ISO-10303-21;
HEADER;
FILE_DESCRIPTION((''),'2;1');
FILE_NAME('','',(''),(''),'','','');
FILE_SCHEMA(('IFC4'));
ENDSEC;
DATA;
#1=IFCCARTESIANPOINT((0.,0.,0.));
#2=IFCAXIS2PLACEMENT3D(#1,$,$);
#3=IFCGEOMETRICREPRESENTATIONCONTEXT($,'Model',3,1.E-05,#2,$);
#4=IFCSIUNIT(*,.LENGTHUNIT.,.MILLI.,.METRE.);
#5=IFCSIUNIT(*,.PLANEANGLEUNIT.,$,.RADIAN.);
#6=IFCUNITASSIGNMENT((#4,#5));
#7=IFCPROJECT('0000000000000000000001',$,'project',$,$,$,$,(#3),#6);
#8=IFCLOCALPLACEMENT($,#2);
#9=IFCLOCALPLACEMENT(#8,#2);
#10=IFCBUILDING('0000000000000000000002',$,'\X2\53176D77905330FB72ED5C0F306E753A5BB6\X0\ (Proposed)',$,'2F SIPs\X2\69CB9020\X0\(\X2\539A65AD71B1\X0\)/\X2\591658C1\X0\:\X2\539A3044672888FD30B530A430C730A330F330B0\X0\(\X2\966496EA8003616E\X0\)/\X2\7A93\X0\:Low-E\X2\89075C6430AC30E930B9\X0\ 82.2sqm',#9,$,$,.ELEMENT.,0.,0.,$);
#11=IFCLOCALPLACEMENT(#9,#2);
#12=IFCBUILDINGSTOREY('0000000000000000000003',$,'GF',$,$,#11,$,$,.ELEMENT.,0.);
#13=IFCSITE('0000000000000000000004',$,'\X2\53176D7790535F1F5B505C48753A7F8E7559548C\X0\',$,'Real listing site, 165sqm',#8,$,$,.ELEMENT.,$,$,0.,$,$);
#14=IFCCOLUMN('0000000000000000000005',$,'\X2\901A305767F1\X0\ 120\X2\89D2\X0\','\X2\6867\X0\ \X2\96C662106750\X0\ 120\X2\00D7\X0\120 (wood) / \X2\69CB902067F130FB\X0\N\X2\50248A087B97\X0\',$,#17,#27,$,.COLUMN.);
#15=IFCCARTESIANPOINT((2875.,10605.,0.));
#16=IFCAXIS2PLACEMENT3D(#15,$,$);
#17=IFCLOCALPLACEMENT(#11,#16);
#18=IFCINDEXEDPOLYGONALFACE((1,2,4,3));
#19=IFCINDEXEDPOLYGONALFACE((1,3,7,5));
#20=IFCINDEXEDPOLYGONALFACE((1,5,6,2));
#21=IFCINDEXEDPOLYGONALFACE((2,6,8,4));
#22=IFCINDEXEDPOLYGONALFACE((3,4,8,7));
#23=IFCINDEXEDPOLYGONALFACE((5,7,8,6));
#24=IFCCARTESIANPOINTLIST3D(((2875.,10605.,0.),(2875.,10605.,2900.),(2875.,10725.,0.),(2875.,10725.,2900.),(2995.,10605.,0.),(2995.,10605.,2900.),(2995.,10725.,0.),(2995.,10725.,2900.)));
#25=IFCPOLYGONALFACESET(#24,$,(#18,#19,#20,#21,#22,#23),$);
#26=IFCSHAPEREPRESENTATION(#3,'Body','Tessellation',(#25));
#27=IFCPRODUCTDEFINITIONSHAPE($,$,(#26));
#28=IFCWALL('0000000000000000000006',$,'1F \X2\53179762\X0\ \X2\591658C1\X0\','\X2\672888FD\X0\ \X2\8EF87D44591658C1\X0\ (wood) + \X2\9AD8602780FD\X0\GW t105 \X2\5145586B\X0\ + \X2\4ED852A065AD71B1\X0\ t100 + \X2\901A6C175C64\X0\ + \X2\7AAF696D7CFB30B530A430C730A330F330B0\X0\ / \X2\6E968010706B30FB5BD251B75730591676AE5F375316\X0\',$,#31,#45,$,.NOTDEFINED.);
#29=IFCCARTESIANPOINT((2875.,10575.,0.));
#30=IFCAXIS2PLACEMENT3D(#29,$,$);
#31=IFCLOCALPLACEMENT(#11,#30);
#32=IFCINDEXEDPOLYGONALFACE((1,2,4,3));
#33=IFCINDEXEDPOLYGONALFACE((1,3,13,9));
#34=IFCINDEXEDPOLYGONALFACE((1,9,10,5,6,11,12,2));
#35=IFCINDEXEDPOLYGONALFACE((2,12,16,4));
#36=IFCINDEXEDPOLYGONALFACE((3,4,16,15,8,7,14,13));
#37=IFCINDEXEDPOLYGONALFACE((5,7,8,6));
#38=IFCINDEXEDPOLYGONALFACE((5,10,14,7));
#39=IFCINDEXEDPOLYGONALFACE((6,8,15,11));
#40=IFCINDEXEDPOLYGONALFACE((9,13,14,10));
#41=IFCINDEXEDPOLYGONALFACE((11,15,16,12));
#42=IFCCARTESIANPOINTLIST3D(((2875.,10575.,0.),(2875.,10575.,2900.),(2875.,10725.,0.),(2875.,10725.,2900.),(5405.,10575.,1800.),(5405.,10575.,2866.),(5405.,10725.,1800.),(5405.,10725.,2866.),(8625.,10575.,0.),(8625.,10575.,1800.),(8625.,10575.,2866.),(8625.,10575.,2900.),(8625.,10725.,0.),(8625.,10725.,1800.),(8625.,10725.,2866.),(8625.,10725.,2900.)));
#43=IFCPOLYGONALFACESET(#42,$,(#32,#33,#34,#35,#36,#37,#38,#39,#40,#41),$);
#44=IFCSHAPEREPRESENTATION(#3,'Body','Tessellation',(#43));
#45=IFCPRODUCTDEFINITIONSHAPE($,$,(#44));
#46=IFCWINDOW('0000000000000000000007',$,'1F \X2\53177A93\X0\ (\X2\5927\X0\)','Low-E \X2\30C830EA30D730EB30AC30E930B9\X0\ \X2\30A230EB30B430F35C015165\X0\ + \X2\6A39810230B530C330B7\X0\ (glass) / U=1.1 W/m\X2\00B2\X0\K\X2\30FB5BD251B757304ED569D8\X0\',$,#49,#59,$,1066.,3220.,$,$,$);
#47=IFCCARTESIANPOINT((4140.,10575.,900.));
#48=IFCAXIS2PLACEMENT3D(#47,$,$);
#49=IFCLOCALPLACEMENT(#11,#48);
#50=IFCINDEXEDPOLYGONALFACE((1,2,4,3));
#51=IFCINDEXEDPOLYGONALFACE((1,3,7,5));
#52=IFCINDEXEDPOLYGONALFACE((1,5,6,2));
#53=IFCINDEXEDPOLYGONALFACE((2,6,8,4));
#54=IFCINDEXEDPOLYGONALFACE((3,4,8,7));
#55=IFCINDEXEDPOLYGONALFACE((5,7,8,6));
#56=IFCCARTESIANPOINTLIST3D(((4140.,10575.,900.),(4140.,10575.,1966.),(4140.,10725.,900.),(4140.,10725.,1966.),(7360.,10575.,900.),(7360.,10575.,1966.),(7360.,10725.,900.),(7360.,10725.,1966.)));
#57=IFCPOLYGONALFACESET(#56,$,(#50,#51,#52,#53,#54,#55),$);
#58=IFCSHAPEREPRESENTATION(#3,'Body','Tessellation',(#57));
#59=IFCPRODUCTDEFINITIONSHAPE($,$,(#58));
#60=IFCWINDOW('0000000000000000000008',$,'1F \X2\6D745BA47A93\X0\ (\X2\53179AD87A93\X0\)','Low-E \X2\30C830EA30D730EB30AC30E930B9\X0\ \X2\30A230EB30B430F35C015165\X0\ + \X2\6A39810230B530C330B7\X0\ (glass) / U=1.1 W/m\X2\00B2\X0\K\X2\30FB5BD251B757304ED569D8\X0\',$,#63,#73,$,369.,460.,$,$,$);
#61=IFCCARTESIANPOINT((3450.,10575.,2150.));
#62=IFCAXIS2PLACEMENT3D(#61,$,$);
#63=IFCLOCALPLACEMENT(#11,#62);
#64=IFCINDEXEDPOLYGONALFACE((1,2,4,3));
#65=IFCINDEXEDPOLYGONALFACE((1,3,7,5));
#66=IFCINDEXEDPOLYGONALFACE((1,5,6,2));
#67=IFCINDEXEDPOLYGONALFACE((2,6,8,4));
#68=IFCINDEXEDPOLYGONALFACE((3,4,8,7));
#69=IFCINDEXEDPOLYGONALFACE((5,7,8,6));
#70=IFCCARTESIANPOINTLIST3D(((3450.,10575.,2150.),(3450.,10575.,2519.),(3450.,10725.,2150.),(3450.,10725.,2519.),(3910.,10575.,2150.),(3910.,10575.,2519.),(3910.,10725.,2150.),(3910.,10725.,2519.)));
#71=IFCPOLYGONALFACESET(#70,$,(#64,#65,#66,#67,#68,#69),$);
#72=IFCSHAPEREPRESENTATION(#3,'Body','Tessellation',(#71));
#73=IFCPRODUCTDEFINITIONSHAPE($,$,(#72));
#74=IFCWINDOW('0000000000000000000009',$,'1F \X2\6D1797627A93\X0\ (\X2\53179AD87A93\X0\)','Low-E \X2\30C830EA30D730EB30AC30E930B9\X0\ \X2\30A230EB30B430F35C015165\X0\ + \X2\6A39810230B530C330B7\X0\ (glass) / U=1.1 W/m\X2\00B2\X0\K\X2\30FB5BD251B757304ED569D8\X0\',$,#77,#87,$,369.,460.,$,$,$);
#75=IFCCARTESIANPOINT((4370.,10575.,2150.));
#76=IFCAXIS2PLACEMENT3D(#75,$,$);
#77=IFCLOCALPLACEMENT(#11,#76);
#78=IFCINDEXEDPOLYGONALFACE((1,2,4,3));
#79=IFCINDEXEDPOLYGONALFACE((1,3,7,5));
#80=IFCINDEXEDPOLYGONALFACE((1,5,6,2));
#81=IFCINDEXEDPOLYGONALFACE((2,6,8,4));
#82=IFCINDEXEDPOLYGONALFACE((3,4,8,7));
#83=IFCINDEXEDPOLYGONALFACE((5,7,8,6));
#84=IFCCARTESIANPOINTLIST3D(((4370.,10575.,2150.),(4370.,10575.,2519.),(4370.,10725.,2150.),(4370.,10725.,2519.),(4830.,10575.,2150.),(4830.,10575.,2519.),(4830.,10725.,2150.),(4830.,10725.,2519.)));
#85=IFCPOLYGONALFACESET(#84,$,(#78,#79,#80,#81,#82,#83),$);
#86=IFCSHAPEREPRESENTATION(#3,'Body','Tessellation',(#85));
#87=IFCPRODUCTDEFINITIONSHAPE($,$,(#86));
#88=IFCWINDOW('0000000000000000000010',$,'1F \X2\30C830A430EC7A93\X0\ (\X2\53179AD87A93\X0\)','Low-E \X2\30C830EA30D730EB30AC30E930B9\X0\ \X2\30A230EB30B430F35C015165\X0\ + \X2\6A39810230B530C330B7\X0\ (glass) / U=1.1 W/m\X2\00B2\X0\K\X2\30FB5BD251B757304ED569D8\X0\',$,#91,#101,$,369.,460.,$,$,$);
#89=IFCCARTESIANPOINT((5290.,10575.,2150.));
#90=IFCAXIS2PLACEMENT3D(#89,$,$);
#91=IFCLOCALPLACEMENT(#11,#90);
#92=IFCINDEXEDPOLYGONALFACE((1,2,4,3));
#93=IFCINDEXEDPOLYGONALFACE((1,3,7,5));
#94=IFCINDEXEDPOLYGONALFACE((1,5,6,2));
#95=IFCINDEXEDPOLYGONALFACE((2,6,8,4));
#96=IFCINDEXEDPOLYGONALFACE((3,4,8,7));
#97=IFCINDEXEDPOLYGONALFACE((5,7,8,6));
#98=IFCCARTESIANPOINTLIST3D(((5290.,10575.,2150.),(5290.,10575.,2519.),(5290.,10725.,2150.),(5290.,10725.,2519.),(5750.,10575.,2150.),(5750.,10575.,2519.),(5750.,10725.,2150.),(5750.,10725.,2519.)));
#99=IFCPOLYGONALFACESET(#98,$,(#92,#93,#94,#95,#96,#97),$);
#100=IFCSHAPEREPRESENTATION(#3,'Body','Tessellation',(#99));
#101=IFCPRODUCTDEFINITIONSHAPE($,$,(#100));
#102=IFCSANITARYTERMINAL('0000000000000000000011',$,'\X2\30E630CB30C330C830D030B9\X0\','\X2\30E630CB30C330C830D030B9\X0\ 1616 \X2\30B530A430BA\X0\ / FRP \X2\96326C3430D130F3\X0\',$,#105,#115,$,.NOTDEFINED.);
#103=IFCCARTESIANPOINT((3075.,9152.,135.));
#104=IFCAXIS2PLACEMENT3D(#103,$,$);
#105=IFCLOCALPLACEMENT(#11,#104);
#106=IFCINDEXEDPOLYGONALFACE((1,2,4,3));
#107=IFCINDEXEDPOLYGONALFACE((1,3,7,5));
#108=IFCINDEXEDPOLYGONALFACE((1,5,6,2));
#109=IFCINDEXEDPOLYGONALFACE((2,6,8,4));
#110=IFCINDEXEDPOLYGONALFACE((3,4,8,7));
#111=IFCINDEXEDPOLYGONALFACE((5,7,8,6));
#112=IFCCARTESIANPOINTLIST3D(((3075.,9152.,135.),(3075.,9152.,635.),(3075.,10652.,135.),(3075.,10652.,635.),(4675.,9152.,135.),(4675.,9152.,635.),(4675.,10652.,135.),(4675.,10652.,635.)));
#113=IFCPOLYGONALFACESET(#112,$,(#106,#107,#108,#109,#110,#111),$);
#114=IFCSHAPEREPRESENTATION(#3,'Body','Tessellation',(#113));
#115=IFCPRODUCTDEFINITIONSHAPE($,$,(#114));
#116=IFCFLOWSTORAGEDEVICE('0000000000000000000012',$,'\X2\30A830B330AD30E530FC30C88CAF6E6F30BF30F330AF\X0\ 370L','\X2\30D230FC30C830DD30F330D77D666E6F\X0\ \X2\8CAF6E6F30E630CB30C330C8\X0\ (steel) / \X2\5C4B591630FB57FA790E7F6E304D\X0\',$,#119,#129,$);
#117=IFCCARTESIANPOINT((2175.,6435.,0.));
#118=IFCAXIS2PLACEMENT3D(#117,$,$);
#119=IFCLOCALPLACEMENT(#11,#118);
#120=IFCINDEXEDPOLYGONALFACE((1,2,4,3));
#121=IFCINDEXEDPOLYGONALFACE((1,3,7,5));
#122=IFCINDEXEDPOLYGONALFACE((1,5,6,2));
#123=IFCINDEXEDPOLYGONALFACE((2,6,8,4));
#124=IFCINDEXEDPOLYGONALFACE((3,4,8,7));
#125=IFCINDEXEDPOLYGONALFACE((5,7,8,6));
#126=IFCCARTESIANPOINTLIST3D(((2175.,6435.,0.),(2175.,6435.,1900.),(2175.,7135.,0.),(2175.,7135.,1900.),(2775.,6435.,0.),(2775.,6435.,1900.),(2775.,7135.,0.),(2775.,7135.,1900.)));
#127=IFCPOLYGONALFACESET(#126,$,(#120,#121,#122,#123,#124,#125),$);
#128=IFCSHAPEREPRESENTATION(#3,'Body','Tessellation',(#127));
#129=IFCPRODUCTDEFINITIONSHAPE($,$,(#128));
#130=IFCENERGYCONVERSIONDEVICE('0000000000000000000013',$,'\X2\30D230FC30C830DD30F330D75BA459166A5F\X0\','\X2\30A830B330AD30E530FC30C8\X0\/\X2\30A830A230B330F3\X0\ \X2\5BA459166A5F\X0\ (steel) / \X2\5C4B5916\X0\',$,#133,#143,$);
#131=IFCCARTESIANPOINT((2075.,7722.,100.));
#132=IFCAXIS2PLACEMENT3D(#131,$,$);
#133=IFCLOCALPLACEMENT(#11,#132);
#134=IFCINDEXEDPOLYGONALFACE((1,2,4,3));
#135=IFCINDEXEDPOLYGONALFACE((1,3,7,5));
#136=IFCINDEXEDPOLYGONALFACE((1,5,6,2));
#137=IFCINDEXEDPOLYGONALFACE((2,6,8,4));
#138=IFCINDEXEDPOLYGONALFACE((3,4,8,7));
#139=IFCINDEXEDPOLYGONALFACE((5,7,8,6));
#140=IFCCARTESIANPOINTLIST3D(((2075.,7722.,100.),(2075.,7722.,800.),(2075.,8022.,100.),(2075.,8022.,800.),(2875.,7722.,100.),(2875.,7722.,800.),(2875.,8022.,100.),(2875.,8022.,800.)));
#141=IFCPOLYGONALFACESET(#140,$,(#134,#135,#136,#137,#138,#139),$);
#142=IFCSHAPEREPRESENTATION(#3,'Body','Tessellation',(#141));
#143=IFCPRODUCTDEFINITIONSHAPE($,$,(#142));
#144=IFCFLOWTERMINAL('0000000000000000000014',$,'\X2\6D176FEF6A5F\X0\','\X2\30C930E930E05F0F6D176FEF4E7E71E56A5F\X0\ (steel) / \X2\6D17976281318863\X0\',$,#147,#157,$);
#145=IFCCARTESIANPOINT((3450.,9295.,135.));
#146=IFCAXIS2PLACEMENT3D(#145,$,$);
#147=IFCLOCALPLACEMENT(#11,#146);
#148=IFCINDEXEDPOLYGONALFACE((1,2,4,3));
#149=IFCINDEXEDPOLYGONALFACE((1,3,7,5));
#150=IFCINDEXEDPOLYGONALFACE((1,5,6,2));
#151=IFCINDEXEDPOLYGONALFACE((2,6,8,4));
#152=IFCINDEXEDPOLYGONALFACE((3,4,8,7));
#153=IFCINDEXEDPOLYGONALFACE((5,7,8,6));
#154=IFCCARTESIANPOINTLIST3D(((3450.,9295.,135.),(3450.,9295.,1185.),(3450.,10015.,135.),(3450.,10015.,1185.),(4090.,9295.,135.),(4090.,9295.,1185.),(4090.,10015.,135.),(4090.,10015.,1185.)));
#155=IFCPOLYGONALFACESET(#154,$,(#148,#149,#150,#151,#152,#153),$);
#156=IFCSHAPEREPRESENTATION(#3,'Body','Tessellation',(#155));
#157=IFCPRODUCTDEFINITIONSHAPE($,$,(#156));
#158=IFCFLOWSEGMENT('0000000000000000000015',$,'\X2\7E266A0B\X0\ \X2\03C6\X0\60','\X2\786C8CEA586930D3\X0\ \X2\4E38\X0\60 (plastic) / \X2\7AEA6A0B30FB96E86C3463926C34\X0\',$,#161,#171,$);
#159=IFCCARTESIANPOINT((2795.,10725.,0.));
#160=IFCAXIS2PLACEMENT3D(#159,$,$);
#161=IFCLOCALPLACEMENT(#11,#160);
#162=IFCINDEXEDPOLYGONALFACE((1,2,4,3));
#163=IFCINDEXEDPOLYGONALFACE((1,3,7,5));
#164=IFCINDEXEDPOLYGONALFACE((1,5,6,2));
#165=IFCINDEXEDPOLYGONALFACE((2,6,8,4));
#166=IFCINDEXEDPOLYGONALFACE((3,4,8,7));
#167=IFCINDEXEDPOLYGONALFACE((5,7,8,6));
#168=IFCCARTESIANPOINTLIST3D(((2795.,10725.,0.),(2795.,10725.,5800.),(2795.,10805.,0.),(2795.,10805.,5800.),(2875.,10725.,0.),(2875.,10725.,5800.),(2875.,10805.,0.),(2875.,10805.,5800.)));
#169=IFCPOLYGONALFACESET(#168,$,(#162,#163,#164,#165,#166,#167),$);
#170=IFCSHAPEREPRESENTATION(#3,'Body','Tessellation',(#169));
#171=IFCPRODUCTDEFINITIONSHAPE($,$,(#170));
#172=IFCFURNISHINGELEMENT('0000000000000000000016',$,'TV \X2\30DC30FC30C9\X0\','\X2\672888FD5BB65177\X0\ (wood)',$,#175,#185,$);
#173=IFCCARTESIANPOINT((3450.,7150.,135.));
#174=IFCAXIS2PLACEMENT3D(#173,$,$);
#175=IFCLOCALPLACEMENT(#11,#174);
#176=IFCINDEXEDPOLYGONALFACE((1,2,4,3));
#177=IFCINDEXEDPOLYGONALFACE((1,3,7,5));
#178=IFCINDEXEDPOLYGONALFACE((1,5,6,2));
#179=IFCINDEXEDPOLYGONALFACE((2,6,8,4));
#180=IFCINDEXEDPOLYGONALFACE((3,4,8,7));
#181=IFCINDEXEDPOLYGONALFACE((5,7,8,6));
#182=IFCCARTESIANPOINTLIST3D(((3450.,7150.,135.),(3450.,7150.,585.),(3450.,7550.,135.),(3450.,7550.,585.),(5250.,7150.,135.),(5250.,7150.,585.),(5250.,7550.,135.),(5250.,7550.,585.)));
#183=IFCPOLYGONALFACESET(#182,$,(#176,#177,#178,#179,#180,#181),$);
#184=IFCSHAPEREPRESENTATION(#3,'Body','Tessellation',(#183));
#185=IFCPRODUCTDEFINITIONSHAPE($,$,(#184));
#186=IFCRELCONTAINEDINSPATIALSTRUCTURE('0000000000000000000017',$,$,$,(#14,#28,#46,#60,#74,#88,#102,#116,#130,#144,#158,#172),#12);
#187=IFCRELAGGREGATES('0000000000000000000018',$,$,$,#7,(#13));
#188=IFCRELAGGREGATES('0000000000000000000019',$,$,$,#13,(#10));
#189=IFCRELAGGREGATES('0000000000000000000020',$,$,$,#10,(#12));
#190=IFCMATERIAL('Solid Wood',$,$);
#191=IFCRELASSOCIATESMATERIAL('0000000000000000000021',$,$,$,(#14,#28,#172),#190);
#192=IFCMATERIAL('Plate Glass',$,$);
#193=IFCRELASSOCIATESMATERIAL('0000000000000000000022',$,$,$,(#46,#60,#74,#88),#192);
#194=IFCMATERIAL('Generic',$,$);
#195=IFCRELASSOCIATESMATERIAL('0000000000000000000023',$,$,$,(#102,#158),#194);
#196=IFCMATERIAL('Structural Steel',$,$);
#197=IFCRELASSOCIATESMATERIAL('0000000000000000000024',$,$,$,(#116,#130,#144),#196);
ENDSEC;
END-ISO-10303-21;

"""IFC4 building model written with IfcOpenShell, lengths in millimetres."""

from ifc_helpers import new_model, si_unit, frame, frame_2d, origin, place, context, project, spatial, rectangle, extrude, material, element, fill, save


model = new_model("IFC4")

# Units and contexts
model_context = context("Model", 3, precision=1e-05, world=origin())
ifc_project = project(units=[si_unit("LENGTHUNIT", "METRE", prefix="MILLI"), si_unit("PLANEANGLEUNIT", "RADIAN")], contexts=[model_context])

# Site, building, storey
site_placement = place(None, origin())
site = spatial("IfcSite", under=ifc_project, at=site_placement, Name="北海道弟子屈町美留和", ObjectType="Real listing site, 165sqm", CompositionType="ELEMENT", RefElevation=0.0)
building_placement = place(site_placement, origin())
building = spatial("IfcBuilding", under=site, at=building_placement, Name="北海道・狭小の町家 (Proposed)", ObjectType="2F SIPs構造(厚断熱)/外壁:厚い木製サイディング(除雪考慮)/窓:Low-E複層ガラス 82.2sqm", CompositionType="ELEMENT", ElevationOfRefHeight=0.0, ElevationOfTerrain=0.0)
storey_placement = place(building_placement, origin())
storey = spatial("IfcBuildingStorey", under=building, at=storey_placement, Name="GF", CompositionType="ELEMENT", Elevation=0.0)

# Column
ifc_material_1 = material(Name="Solid Wood")
column_1_placement = place(storey_placement, frame((2875.0, 10605.0, 0.0)))
element("IfcColumn", 1, at=column_1_placement, inside=storey, material=ifc_material_1, Name="通し柱 120角", Description="桧 集成材 120×120 (wood) / 構造柱・N値計算", PredefinedType="COLUMN", context=model_context, shape_type="SweptSolid", body=[
    extrude(rectangle(XDim=120.0, YDim=120.0, at=frame_2d((60.0, 60.0))), frame((2875.0, 10605.0, 0.0)), (0.0, 0.0, 1.0), 2900.0),
])

# Wall, openings, windows
wall_1_placement = place(storey_placement, frame((2875.0, 10575.0, 0.0)))
wall_1 = element("IfcWall", 2, at=wall_1_placement, inside=storey, material=ifc_material_1, Name="1F 北面 外壁", Description="木製 軸組外壁 (wood) + 高性能GW t105 充填 + 付加断熱 t100 + 通気層 + 窯業系サイディング / 準耐火・寒冷地外皮強化", PredefinedType="NOTDEFINED", context=model_context, shape_type="SweptSolid", body=[
    extrude(rectangle(XDim=5750.0, YDim=150.0, at=frame_2d((2875.0, 75.0))), frame((2875.0, 10575.0, 0.0)), (0.0, 0.0, 1.0), 2900.0),
])
opening_1_placement = place(storey_placement, frame((4140.0, 10575.0, 900.0)))
opening_1 = element("IfcOpeningElement", 3, at=opening_1_placement, cuts=wall_1, PredefinedType="NOTDEFINED", context=model_context, shape_type="SweptSolid", body=[
    extrude(rectangle(XDim=3220.0, YDim=150.0, at=frame_2d((1610.0, 75.0))), frame((4140.0, 10575.0, 900.0)), (0.0, 0.0, 1.0), 1066.0),
])
opening_2_placement = place(storey_placement, frame((3450.0, 10575.0, 2150.0)))
opening_2 = element("IfcOpeningElement", 4, at=opening_2_placement, cuts=wall_1, PredefinedType="NOTDEFINED", context=model_context, shape_type="SweptSolid", body=[
    extrude(rectangle(XDim=460.0, YDim=150.0, at=frame_2d((230.0, 75.0))), frame((3450.0, 10575.0, 2150.0)), (0.0, 0.0, 1.0), 369.0),
])
opening_3_placement = place(storey_placement, frame((4370.0, 10575.0, 2150.0)))
opening_3 = element("IfcOpeningElement", 5, at=opening_3_placement, cuts=wall_1, PredefinedType="NOTDEFINED", context=model_context, shape_type="SweptSolid", body=[
    extrude(rectangle(XDim=460.0, YDim=150.0, at=frame_2d((230.0, 75.0))), frame((4370.0, 10575.0, 2150.0)), (0.0, 0.0, 1.0), 369.0),
])
opening_4_placement = place(storey_placement, frame((5290.0, 10575.0, 2150.0)))
opening_4 = element("IfcOpeningElement", 6, at=opening_4_placement, cuts=wall_1, PredefinedType="NOTDEFINED", context=model_context, shape_type="SweptSolid", body=[
    extrude(rectangle(XDim=460.0, YDim=150.0, at=frame_2d((230.0, 75.0))), frame((5290.0, 10575.0, 2150.0)), (0.0, 0.0, 1.0), 369.0),
])
ifc_material_2 = material(Name="Plate Glass")
window_1_placement = place(storey_placement, frame((4140.0, 10575.0, 900.0)))
window_1 = element("IfcWindow", 7, at=window_1_placement, inside=storey, material=ifc_material_2, Name="1F 北窓 (大)", Description="Low-E トリプルガラス アルゴン封入 + 樹脂サッシ (glass) / U=1.1 W/m²K・寒冷地仕様", OverallHeight=1066.0, OverallWidth=3220.0, context=model_context, shape_type="SweptSolid", body=[
    extrude(rectangle(XDim=3220.0, YDim=150.0, at=frame_2d((1610.0, 75.0))), frame((4140.0, 10575.0, 900.0)), (0.0, 0.0, 1.0), 1066.0),
])
fill(opening_1, window_1)
window_2_placement = place(storey_placement, frame((3450.0, 10575.0, 2150.0)))
window_2 = element("IfcWindow", 8, at=window_2_placement, inside=storey, material=ifc_material_2, Name="1F 浴室窓 (北高窓)", Description="Low-E トリプルガラス アルゴン封入 + 樹脂サッシ (glass) / U=1.1 W/m²K・寒冷地仕様", OverallHeight=369.0, OverallWidth=460.0, context=model_context, shape_type="SweptSolid", body=[
    extrude(rectangle(XDim=460.0, YDim=150.0, at=frame_2d((230.0, 75.0))), frame((3450.0, 10575.0, 2150.0)), (0.0, 0.0, 1.0), 369.0),
])
fill(opening_2, window_2)
window_3_placement = place(storey_placement, frame((4370.0, 10575.0, 2150.0)))
window_3 = element("IfcWindow", 9, at=window_3_placement, inside=storey, material=ifc_material_2, Name="1F 洗面窓 (北高窓)", Description="Low-E トリプルガラス アルゴン封入 + 樹脂サッシ (glass) / U=1.1 W/m²K・寒冷地仕様", OverallHeight=369.0, OverallWidth=460.0, context=model_context, shape_type="SweptSolid", body=[
    extrude(rectangle(XDim=460.0, YDim=150.0, at=frame_2d((230.0, 75.0))), frame((4370.0, 10575.0, 2150.0)), (0.0, 0.0, 1.0), 369.0),
])
fill(opening_3, window_3)
window_4_placement = place(storey_placement, frame((5290.0, 10575.0, 2150.0)))
window_4 = element("IfcWindow", 10, at=window_4_placement, inside=storey, material=ifc_material_2, Name="1F トイレ窓 (北高窓)", Description="Low-E トリプルガラス アルゴン封入 + 樹脂サッシ (glass) / U=1.1 W/m²K・寒冷地仕様", OverallHeight=369.0, OverallWidth=460.0, context=model_context, shape_type="SweptSolid", body=[
    extrude(rectangle(XDim=460.0, YDim=150.0, at=frame_2d((230.0, 75.0))), frame((5290.0, 10575.0, 2150.0)), (0.0, 0.0, 1.0), 369.0),
])
fill(opening_4, window_4)

# Sanitary terminal
ifc_material_3 = material(Name="Generic")
sanitary_terminal_placement = place(storey_placement, frame((3075.0, 9152.0, 135.0)))
element("IfcSanitaryTerminal", 11, at=sanitary_terminal_placement, inside=storey, material=ifc_material_3, Name="ユニットバス", Description="ユニットバス 1616 サイズ / FRP 防水パン", PredefinedType="NOTDEFINED", context=model_context, shape_type="SweptSolid", body=[
    extrude(rectangle(XDim=1600.0, YDim=1500.0, at=frame_2d((800.0, 750.0))), frame((3075.0, 9152.0, 135.0)), (0.0, 0.0, 1.0), 500.0),
])

# Flow storage device
ifc_material_4 = material(Name="Structural Steel")
flow_storage_device_placement = place(storey_placement, frame((2175.0, 6435.0, 0.0)))
element("IfcFlowStorageDevice", 12, at=flow_storage_device_placement, inside=storey, material=ifc_material_4, Name="エコキュート貯湯タンク 370L", Description="ヒートポンプ給湯 貯湯ユニット (steel) / 屋外・基礎置き", context=model_context, shape_type="SweptSolid", body=[
    extrude(rectangle(XDim=600.0, YDim=700.0, at=frame_2d((300.0, 350.0))), frame((2175.0, 6435.0, 0.0)), (0.0, 0.0, 1.0), 1900.0),
])

# Energy conversion device
energy_conversion_device_placement = place(storey_placement, frame((2075.0, 7722.0, 100.0)))
element("IfcEnergyConversionDevice", 13, at=energy_conversion_device_placement, inside=storey, material=ifc_material_4, Name="ヒートポンプ室外機", Description="エコキュート/エアコン 室外機 (steel) / 屋外", context=model_context, shape_type="SweptSolid", body=[
    extrude(rectangle(XDim=800.0, YDim=300.0, at=frame_2d((400.0, 150.0))), frame((2075.0, 7722.0, 100.0)), (0.0, 0.0, 1.0), 700.0),
])

# Flow terminal
flow_terminal_placement = place(storey_placement, frame((3450.0, 9295.0, 135.0)))
element("IfcFlowTerminal", 14, at=flow_terminal_placement, inside=storey, material=ifc_material_4, Name="洗濯機", Description="ドラム式洗濯乾燥機 (steel) / 洗面脱衣", context=model_context, shape_type="SweptSolid", body=[
    extrude(rectangle(XDim=640.0, YDim=720.0, at=frame_2d((320.0, 360.0))), frame((3450.0, 9295.0, 135.0)), (0.0, 0.0, 1.0), 1050.0),
])

# Flow segment
flow_segment_placement = place(storey_placement, frame((2795.0, 10725.0, 0.0)))
element("IfcFlowSegment", 15, at=flow_segment_placement, inside=storey, material=ifc_material_3, Name="縦樋 φ60", Description="硬質塩ビ 丸60 (plastic) / 竪樋・雨水排水", context=model_context, shape_type="SweptSolid", body=[
    extrude(rectangle(XDim=80.0, YDim=80.0, at=frame_2d((40.0, 40.0))), frame((2795.0, 10725.0, 0.0)), (0.0, 0.0, 1.0), 5800.0),
])

# Furnishing element
furnishing_placement = place(storey_placement, frame((3450.0, 7150.0, 135.0)))
element("IfcFurnishingElement", 16, at=furnishing_placement, inside=storey, material=ifc_material_1, Name="TV ボード", Description="木製家具 (wood)", context=model_context, shape_type="SweptSolid", body=[
    extrude(rectangle(XDim=1800.0, YDim=400.0, at=frame_2d((900.0, 200.0))), frame((3450.0, 7150.0, 135.0)), (0.0, 0.0, 1.0), 450.0),
])

save(model, "model.ifc")
